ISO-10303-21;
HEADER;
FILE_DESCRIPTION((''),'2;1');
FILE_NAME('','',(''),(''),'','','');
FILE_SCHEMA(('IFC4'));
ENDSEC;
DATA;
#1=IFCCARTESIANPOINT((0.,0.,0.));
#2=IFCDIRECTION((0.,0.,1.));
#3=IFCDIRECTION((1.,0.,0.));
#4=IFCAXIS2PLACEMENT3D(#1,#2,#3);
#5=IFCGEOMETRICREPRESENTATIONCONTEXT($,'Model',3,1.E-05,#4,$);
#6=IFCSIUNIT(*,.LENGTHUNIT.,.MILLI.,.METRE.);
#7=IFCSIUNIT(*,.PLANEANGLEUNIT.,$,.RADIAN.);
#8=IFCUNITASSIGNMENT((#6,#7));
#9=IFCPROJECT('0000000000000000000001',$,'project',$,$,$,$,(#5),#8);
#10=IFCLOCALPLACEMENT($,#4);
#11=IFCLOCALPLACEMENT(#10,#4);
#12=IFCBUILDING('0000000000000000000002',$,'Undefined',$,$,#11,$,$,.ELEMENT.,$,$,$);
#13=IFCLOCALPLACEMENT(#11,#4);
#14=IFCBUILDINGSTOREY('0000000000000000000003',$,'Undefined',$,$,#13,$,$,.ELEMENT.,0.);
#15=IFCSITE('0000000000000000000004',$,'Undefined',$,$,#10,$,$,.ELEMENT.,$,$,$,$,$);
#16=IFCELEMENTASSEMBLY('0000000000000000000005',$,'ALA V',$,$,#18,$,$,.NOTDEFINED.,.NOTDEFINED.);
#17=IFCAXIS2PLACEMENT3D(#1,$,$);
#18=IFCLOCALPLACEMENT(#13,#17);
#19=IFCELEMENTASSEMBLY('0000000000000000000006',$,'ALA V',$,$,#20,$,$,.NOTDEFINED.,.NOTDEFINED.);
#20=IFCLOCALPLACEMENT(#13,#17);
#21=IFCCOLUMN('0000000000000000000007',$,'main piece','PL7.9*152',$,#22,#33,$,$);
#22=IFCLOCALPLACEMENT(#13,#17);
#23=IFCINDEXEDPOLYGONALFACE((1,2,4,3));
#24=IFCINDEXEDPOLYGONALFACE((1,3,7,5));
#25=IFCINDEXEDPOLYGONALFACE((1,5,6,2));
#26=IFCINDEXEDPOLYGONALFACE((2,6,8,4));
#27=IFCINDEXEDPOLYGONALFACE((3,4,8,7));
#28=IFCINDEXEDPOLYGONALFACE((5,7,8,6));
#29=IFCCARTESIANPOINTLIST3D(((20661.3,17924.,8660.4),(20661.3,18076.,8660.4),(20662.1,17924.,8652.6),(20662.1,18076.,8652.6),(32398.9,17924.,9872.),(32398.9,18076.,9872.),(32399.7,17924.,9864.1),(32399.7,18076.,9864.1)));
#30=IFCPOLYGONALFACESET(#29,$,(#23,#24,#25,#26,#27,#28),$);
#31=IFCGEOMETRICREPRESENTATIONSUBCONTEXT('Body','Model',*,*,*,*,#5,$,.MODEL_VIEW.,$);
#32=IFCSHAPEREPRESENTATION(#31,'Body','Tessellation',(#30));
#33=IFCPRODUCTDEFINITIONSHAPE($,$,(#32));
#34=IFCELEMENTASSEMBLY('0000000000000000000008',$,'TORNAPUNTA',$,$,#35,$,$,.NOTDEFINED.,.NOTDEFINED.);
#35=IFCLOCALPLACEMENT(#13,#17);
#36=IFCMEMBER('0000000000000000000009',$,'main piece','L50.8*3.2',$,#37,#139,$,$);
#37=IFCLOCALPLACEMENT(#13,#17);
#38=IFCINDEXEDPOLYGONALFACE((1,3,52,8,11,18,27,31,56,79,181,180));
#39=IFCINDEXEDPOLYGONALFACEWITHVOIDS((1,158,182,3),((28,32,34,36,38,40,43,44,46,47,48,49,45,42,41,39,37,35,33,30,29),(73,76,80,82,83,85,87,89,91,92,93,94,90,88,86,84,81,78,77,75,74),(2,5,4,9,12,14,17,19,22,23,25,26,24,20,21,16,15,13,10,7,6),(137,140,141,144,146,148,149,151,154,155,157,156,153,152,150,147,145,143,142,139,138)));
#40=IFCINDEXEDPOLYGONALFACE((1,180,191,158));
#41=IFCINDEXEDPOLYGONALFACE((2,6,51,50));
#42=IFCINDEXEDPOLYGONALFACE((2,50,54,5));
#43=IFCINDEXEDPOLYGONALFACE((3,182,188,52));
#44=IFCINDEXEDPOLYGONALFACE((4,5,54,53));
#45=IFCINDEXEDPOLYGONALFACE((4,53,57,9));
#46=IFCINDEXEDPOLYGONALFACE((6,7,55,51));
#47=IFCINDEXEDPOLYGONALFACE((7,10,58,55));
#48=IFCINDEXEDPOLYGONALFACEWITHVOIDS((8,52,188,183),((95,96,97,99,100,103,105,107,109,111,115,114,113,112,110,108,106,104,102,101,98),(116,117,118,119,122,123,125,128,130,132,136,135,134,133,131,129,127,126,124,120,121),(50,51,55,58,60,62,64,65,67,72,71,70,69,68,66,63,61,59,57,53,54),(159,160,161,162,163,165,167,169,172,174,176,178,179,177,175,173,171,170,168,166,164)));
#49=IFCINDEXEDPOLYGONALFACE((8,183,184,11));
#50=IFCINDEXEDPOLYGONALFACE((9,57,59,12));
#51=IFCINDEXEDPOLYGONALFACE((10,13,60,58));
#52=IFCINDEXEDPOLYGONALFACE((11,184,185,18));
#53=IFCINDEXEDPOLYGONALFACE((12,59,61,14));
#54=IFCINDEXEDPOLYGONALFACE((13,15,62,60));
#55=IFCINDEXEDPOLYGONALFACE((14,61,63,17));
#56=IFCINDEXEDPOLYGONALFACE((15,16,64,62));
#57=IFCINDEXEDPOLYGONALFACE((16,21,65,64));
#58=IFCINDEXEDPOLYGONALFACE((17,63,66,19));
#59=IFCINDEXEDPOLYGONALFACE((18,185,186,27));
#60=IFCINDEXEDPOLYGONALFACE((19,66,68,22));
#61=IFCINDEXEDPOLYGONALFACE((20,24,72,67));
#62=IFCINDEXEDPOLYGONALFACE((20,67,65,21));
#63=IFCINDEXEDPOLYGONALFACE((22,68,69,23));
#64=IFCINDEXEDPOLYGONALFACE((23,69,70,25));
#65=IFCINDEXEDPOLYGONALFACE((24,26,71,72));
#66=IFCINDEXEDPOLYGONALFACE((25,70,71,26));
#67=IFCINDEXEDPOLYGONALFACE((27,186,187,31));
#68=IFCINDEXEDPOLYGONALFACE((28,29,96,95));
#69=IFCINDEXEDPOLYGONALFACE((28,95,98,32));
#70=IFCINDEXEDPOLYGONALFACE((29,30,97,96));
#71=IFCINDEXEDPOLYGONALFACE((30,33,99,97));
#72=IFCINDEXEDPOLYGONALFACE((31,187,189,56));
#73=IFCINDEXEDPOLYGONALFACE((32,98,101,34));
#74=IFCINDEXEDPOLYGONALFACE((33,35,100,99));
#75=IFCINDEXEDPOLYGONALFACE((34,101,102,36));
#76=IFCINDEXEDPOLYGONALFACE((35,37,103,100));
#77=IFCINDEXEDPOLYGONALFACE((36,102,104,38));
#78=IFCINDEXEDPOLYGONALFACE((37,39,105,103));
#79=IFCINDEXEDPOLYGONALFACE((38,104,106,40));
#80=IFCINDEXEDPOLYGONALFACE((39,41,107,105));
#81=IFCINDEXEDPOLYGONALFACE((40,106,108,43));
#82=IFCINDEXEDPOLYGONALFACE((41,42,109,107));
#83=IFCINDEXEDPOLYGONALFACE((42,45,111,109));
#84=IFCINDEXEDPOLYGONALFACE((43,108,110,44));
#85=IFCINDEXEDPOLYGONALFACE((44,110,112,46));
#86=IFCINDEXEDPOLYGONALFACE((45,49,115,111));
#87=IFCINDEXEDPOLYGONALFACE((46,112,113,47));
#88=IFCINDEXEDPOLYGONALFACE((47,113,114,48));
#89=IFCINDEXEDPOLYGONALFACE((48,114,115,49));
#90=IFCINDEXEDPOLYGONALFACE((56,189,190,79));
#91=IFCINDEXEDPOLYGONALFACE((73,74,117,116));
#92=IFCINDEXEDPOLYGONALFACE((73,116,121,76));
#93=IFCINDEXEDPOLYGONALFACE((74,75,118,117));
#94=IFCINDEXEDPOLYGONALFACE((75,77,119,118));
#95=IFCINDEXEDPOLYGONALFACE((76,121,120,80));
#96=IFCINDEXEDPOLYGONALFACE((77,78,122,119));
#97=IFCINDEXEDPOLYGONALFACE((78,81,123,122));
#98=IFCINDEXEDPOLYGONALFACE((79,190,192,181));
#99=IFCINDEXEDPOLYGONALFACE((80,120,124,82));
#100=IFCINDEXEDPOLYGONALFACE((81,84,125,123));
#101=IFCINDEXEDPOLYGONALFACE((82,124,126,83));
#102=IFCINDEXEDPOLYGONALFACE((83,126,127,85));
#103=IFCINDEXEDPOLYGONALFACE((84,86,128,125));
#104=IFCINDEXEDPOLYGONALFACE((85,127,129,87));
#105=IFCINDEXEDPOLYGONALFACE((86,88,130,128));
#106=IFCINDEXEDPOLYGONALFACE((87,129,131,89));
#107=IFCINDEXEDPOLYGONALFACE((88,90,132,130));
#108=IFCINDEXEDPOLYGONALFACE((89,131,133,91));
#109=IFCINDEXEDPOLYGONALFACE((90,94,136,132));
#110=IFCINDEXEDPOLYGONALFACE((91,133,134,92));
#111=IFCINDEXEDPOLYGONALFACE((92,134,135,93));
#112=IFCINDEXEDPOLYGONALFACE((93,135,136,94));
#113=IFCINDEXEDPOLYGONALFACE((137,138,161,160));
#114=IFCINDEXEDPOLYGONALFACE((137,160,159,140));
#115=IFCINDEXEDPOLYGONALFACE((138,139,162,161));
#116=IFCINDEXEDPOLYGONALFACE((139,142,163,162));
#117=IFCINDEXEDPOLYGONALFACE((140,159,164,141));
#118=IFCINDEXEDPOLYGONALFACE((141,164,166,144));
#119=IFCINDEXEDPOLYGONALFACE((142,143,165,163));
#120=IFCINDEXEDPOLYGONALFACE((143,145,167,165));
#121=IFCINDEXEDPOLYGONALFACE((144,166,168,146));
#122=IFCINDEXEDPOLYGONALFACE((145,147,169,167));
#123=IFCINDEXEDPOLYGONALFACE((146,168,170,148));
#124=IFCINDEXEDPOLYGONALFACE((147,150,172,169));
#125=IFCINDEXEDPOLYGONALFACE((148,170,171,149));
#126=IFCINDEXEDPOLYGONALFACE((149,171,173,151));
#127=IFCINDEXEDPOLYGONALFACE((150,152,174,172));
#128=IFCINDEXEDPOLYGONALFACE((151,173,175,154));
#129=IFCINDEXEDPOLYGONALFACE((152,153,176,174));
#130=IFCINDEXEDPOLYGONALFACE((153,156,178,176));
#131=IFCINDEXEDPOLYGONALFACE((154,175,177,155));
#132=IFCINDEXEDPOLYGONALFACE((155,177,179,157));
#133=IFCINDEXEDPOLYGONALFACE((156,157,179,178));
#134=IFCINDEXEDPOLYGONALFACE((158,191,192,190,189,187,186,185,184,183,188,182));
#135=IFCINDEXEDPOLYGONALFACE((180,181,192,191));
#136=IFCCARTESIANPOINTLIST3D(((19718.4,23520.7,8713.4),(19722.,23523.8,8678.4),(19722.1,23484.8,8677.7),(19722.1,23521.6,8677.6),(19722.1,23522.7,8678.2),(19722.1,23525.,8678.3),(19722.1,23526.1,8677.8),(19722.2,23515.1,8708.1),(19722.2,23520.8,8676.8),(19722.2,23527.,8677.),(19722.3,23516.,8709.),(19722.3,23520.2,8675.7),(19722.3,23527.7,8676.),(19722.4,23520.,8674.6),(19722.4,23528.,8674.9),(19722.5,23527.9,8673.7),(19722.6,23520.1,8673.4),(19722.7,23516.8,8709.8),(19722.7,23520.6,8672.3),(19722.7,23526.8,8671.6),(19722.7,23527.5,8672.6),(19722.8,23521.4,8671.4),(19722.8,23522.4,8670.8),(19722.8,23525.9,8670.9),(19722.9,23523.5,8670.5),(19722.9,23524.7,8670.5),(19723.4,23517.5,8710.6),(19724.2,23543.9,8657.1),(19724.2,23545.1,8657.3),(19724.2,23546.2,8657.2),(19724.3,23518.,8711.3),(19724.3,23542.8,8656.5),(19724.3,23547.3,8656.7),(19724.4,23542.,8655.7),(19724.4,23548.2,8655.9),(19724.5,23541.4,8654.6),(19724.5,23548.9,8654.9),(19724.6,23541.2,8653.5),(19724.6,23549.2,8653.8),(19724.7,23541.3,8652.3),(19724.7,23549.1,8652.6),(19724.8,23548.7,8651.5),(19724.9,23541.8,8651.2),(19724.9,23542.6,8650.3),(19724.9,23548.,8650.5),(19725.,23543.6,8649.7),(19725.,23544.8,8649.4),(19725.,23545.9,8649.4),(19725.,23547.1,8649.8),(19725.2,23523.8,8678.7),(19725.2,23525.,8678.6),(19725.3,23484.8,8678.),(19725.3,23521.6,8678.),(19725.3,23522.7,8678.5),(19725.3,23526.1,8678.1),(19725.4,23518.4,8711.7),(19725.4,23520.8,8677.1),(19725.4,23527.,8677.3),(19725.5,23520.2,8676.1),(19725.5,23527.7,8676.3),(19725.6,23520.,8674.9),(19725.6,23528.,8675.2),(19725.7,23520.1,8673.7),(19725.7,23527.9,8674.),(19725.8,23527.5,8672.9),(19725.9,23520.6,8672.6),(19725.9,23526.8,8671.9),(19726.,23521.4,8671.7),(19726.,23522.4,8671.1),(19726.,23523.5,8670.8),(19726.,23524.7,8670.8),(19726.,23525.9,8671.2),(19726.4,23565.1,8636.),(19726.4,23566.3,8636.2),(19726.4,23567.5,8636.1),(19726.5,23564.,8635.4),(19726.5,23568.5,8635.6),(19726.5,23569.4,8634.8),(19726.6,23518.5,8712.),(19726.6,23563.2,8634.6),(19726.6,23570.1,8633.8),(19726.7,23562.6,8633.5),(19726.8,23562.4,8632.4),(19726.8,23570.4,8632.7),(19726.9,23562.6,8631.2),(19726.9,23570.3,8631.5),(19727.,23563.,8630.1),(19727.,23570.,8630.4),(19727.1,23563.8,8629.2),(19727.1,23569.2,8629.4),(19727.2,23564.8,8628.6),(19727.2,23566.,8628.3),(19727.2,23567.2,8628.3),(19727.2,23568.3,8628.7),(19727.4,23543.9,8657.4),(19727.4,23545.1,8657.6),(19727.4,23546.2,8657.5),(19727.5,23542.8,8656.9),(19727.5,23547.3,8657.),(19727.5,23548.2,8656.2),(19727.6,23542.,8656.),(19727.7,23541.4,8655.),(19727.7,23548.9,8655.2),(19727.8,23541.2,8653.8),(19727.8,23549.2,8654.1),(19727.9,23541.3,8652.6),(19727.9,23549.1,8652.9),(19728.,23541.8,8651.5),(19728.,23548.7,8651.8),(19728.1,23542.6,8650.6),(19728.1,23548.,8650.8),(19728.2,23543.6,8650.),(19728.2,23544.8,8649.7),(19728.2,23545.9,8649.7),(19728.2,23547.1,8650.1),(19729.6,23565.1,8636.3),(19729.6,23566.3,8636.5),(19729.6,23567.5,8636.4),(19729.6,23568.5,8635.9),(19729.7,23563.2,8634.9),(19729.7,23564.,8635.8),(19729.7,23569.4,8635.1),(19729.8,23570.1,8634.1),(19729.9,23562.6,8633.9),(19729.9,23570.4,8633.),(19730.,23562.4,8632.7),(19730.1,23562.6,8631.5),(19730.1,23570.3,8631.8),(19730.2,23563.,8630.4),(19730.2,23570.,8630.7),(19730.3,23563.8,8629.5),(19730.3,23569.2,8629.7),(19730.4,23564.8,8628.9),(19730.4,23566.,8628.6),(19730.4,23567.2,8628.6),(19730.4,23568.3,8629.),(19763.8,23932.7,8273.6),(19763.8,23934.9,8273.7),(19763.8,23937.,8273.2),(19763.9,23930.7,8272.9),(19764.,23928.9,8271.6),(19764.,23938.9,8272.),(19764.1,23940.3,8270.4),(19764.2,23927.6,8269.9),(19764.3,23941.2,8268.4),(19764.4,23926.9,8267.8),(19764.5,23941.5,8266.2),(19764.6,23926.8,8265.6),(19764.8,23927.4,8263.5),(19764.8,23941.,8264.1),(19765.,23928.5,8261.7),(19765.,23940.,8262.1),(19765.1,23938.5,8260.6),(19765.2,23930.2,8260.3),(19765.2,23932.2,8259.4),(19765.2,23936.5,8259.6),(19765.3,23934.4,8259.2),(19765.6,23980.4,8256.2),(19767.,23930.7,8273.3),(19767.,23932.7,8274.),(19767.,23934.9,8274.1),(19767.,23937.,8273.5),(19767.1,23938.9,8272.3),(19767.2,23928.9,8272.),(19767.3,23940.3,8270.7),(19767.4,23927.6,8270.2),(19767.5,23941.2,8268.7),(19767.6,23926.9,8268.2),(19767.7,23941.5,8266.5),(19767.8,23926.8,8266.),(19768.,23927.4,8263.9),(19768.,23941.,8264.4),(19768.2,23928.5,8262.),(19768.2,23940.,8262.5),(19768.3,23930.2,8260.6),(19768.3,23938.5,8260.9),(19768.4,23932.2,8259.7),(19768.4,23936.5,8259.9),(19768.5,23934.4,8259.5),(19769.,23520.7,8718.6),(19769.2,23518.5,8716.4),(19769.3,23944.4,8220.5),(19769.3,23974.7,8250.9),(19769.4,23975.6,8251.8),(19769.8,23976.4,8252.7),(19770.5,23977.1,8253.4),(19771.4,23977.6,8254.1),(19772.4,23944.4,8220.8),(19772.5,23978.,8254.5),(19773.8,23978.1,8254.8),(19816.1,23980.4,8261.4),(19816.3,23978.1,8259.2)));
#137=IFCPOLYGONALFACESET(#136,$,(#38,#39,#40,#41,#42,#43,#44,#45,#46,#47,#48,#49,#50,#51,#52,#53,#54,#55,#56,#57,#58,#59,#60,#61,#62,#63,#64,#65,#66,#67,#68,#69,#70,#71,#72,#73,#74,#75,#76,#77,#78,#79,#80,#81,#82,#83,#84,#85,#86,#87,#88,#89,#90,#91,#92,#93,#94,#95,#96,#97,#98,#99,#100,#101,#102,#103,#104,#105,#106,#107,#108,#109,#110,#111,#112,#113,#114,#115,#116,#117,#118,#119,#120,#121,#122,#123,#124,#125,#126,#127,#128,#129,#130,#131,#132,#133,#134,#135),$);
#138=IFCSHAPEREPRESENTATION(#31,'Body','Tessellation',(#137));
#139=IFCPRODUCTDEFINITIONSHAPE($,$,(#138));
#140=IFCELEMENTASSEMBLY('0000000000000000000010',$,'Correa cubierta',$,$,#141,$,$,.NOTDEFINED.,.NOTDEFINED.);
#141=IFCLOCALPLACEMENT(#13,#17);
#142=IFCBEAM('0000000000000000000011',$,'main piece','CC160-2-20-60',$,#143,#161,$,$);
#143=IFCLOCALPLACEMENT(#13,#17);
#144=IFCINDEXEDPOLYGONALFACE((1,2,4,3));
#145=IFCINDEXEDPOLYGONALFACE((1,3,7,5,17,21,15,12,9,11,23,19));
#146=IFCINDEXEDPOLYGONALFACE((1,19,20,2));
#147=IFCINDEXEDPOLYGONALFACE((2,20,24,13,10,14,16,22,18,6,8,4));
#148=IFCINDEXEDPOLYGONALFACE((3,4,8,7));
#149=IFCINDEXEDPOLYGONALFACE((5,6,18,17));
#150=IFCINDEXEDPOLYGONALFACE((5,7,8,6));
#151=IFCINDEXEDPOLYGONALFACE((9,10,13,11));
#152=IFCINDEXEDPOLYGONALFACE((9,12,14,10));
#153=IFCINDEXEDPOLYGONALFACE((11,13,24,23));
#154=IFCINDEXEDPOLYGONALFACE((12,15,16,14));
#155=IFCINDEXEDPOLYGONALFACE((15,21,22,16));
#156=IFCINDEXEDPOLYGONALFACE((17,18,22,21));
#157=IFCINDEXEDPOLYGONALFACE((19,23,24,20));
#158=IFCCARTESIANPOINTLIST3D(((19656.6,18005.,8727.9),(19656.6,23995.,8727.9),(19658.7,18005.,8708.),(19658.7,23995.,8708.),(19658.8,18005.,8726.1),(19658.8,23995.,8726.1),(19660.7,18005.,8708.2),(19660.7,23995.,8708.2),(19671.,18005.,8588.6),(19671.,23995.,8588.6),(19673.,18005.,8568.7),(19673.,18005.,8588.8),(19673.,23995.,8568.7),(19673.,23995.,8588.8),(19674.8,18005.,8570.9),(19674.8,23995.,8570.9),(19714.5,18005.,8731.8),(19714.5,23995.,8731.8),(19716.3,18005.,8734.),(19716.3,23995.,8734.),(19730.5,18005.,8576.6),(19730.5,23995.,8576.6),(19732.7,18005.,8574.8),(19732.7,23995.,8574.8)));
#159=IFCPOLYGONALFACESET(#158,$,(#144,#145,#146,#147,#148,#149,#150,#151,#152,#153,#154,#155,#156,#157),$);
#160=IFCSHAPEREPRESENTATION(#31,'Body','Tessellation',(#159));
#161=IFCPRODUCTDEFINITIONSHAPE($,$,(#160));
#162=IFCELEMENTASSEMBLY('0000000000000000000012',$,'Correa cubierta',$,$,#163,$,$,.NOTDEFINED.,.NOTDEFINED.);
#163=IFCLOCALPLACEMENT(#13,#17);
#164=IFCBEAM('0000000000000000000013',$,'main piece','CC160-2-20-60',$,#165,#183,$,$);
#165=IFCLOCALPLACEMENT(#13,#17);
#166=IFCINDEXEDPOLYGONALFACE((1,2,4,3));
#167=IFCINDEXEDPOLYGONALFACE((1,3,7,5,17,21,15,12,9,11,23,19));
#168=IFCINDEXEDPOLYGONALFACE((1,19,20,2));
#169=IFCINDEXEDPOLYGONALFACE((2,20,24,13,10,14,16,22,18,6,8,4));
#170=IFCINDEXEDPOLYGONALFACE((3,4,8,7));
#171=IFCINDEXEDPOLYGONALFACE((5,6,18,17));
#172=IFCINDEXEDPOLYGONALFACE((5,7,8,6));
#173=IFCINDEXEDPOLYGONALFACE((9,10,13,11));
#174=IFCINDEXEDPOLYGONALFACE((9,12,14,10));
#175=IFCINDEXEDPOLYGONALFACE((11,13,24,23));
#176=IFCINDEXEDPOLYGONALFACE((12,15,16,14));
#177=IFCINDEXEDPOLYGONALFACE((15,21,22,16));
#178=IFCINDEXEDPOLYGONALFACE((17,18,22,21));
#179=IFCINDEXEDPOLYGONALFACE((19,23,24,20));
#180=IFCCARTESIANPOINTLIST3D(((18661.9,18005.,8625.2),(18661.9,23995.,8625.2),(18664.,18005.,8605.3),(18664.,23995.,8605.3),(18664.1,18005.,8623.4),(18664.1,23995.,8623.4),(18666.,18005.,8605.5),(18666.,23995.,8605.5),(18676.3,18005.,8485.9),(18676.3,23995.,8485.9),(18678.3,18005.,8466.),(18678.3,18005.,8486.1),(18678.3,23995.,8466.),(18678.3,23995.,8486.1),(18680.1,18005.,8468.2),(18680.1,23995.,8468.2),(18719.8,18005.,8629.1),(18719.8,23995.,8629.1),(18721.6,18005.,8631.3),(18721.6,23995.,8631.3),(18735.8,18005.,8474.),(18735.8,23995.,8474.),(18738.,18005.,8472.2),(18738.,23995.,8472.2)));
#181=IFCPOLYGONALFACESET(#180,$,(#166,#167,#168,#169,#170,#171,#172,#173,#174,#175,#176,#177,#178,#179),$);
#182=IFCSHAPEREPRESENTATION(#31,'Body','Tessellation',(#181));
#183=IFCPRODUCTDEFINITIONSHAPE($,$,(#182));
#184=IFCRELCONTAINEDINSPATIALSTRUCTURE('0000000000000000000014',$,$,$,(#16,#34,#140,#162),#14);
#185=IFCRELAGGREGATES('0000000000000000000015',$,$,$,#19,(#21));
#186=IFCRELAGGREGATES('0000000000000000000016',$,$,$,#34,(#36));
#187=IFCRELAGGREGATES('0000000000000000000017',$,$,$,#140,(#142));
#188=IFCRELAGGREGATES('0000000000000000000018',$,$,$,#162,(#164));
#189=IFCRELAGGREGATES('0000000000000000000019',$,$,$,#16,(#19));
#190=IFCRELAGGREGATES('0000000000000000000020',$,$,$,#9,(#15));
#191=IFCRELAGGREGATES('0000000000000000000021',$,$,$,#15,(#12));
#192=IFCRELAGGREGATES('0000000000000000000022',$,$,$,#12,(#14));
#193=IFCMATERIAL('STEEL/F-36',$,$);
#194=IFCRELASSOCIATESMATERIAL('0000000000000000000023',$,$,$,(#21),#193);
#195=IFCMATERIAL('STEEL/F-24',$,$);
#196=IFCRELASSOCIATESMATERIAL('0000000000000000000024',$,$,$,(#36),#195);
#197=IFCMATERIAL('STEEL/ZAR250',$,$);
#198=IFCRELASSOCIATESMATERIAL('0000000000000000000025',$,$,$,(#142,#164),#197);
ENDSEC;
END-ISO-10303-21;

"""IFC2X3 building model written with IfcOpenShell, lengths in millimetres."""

from ifc_helpers import new_model, si_unit, frame, origin_with_axes, origin_2d_with_axis, place, context, subcontext, project, spatial, rectangle, circle, l_section, c_section, extrude, source, transform, mapped, material, element, aggregate, save


model = new_model("IFC2X3")

# Units and contexts
model_context = context("Model", 3, precision=1e-05, world=origin_with_axes())
body_context = subcontext(model_context, "Body", "Model", "MODEL_VIEW")
ifc_project = project(units=[si_unit("LENGTHUNIT", "METRE", prefix="MILLI"), si_unit("PLANEANGLEUNIT", "RADIAN")], contexts=[model_context])

# Site, building, storey
site_placement = place(None, origin_with_axes())
site = spatial("IfcSite", under=ifc_project, at=site_placement, Name="Undefined", CompositionType="ELEMENT")
building_placement = place(site_placement, origin_with_axes())
building = spatial("IfcBuilding", under=site, at=building_placement, Name="Undefined", CompositionType="ELEMENT")
storey_placement = place(building_placement, origin_with_axes())
storey = spatial("IfcBuildingStorey", under=building, at=storey_placement, Name="Undefined", CompositionType="ELEMENT", Elevation=0.0)

# Element assemblies, column
assembly_1_placement = place(storey_placement, origin_with_axes())
assembly_1 = element("IfcElementAssembly", 1, at=assembly_1_placement, inside=storey, Name="ALA V", AssemblyPlace="NOTDEFINED", PredefinedType="NOTDEFINED")
assembly_2_placement = place(assembly_1_placement, origin_with_axes())
assembly_2 = element("IfcElementAssembly", 2, at=assembly_2_placement, Name="ALA V", AssemblyPlace="NOTDEFINED", PredefinedType="NOTDEFINED")
ifc_material_1 = material(Name="STEEL/F-36")
column_placement = place(assembly_2_placement, frame((20661.7, 18000.0, 8656.5), z_axis=(0.994715, 0.0, 0.102675), x_axis=(0.0, -1.0, 0.0)))
column = element("IfcColumn", 3, at=column_placement, material=ifc_material_1, Name="main piece", Description="PL7.9*152", context=body_context, shape_type="SweptSolid", body=[
    extrude(rectangle(XDim=7.9, YDim=152.0, at=origin_2d_with_axis()), frame((0.0, 0.0, 11800.0), z_axis=(0.0, 0.0, -1.0), x_axis=(0.0, 1.0, 0.0)), (0.0, 0.0, 1.0), 11800.0),
])
aggregate(assembly_2, [column])

# Element assembly, member, openings
assembly_3_placement = place(storey_placement, origin_with_axes())
assembly_3 = element("IfcElementAssembly", 4, at=assembly_3_placement, inside=storey, Name="TORNAPUNTA", AssemblyPlace="NOTDEFINED", PredefinedType="NOTDEFINED")
ifc_material_2 = material(Name="STEEL/F-24")
member_placement = place(assembly_3_placement, frame((19745.5, 23502.8, 8698.1), z_axis=(0.994727, 0.0, 0.102562), x_axis=(0.072522, 0.707107, -0.703378)))
member = element("IfcMember", 5, at=member_placement, material=ifc_material_2, Name="main piece", Description="L50.8*3.2", context=body_context, shape_type="SweptSolid", body=[
    extrude(l_section(Depth=50.8, Width=50.8, Thickness=3.2, FilletRadius=4.8, at=origin_2d_with_axis()), frame((650.0, 0.0, 0.0), z_axis=(-1.0, 0.0, 0.0), x_axis=(0.0, -1.0, 0.0)), (0.0, 0.0, 1.0), 650.0),
])
shared_shape_1 = source(origin_with_axes(), body_context, "Body", "SweptSolid", [
    extrude(circle(Radius=4.0, at=origin_2d_with_axis()), frame((0.0, -3.3, 0.0), z_axis=(0.0, 1.0, 0.0), x_axis=(1.0, 0.0, 0.0)), (0.0, 0.0, 1.0), 3.4),
])
opening_1_placement = place(assembly_3_placement, frame((19722.5, 23524.0, 8674.4), z_axis=(-0.072522, 0.707107, 0.703378), x_axis=(0.072522, 0.707107, -0.703378)))
element("IfcOpeningElement", 6, at=opening_1_placement, cuts=member, ObjectType="Opening", context=body_context, shape_type="MappedRepresentation", body=[
    mapped(shared_shape_1, transform((0.0, 0.0, 0.0))),
    mapped(shared_shape_1, transform((30.0, 0.0, 0.0))),
    mapped(shared_shape_1, transform((60.0, 0.0, 0.0))),
])
shared_shape_2 = source(origin_with_axes(), body_context, "Body", "SweptSolid", [
    extrude(circle(Radius=7.3, at=origin_2d_with_axis()), frame((0.0, -3.3, 0.0), z_axis=(0.0, 1.0, 0.0), x_axis=(1.0, 0.0, 0.0)), (0.0, 0.0, 1.0), 3.4),
])
opening_2_placement = place(assembly_3_placement, frame((19764.5, 23934.1, 8266.5), z_axis=(0.072522, -0.707107, -0.703378), x_axis=(-0.072522, -0.707107, 0.703378)))
element("IfcOpeningElement", 7, at=opening_2_placement, cuts=member, ObjectType="Opening", context=body_context, shape_type="MappedRepresentation", body=[
    mapped(shared_shape_2, transform((0.0, 0.0, 0.0))),
])
aggregate(assembly_3, [member])

# Element assemblies, beams
assembly_4_placement = place(storey_placement, origin_with_axes())
assembly_4 = element("IfcElementAssembly", 8, at=assembly_4_placement, inside=storey, Name="Correa cubierta", AssemblyPlace="NOTDEFINED", PredefinedType="NOTDEFINED")
ifc_material_3 = material(Name="STEEL/ZAR250")
beam_1_placement = place(assembly_4_placement, frame((19694.7, 23995.0, 8651.4), z_axis=(-0.102562, 0.0, 0.994727), x_axis=(0.0, -1.0, 0.0)))
beam_1 = element("IfcBeam", 9, at=beam_1_placement, material=ifc_material_3, Name="main piece", Description="CC160-2-20-60", context=body_context, shape_type="SweptSolid", body=[
    extrude(c_section(Depth=160.0, Width=60.0, WallThickness=2.0, Girth=20.0, at=origin_2d_with_axis()), frame((5990.0, 0.0, 0.0), z_axis=(-1.0, 0.0, 0.0), x_axis=(0.0, -1.0, 0.0)), (0.0, 0.0, 1.0), 5990.0),
])
aggregate(assembly_4, [beam_1])
assembly_5_placement = place(storey_placement, origin_with_axes())
assembly_5 = element("IfcElementAssembly", 10, at=assembly_5_placement, inside=storey, Name="Correa cubierta", AssemblyPlace="NOTDEFINED", PredefinedType="NOTDEFINED")
beam_2_placement = place(assembly_5_placement, frame((18700.0, 23995.0, 8548.7), z_axis=(-0.102562, 0.0, 0.994727), x_axis=(0.0, -1.0, 0.0)))
beam_2 = element("IfcBeam", 11, at=beam_2_placement, material=ifc_material_3, Name="main piece", Description="CC160-2-20-60", context=body_context, shape_type="SweptSolid", body=[
    extrude(c_section(Depth=160.0, Width=60.0, WallThickness=2.0, Girth=20.0, at=origin_2d_with_axis()), frame((5990.0, 0.0, 0.0), z_axis=(-1.0, 0.0, 0.0), x_axis=(0.0, -1.0, 0.0)), (0.0, 0.0, 1.0), 5990.0),
])
aggregate(assembly_5, [beam_2])

aggregate(assembly_1, [assembly_2])

save(model, "model.ifc")
